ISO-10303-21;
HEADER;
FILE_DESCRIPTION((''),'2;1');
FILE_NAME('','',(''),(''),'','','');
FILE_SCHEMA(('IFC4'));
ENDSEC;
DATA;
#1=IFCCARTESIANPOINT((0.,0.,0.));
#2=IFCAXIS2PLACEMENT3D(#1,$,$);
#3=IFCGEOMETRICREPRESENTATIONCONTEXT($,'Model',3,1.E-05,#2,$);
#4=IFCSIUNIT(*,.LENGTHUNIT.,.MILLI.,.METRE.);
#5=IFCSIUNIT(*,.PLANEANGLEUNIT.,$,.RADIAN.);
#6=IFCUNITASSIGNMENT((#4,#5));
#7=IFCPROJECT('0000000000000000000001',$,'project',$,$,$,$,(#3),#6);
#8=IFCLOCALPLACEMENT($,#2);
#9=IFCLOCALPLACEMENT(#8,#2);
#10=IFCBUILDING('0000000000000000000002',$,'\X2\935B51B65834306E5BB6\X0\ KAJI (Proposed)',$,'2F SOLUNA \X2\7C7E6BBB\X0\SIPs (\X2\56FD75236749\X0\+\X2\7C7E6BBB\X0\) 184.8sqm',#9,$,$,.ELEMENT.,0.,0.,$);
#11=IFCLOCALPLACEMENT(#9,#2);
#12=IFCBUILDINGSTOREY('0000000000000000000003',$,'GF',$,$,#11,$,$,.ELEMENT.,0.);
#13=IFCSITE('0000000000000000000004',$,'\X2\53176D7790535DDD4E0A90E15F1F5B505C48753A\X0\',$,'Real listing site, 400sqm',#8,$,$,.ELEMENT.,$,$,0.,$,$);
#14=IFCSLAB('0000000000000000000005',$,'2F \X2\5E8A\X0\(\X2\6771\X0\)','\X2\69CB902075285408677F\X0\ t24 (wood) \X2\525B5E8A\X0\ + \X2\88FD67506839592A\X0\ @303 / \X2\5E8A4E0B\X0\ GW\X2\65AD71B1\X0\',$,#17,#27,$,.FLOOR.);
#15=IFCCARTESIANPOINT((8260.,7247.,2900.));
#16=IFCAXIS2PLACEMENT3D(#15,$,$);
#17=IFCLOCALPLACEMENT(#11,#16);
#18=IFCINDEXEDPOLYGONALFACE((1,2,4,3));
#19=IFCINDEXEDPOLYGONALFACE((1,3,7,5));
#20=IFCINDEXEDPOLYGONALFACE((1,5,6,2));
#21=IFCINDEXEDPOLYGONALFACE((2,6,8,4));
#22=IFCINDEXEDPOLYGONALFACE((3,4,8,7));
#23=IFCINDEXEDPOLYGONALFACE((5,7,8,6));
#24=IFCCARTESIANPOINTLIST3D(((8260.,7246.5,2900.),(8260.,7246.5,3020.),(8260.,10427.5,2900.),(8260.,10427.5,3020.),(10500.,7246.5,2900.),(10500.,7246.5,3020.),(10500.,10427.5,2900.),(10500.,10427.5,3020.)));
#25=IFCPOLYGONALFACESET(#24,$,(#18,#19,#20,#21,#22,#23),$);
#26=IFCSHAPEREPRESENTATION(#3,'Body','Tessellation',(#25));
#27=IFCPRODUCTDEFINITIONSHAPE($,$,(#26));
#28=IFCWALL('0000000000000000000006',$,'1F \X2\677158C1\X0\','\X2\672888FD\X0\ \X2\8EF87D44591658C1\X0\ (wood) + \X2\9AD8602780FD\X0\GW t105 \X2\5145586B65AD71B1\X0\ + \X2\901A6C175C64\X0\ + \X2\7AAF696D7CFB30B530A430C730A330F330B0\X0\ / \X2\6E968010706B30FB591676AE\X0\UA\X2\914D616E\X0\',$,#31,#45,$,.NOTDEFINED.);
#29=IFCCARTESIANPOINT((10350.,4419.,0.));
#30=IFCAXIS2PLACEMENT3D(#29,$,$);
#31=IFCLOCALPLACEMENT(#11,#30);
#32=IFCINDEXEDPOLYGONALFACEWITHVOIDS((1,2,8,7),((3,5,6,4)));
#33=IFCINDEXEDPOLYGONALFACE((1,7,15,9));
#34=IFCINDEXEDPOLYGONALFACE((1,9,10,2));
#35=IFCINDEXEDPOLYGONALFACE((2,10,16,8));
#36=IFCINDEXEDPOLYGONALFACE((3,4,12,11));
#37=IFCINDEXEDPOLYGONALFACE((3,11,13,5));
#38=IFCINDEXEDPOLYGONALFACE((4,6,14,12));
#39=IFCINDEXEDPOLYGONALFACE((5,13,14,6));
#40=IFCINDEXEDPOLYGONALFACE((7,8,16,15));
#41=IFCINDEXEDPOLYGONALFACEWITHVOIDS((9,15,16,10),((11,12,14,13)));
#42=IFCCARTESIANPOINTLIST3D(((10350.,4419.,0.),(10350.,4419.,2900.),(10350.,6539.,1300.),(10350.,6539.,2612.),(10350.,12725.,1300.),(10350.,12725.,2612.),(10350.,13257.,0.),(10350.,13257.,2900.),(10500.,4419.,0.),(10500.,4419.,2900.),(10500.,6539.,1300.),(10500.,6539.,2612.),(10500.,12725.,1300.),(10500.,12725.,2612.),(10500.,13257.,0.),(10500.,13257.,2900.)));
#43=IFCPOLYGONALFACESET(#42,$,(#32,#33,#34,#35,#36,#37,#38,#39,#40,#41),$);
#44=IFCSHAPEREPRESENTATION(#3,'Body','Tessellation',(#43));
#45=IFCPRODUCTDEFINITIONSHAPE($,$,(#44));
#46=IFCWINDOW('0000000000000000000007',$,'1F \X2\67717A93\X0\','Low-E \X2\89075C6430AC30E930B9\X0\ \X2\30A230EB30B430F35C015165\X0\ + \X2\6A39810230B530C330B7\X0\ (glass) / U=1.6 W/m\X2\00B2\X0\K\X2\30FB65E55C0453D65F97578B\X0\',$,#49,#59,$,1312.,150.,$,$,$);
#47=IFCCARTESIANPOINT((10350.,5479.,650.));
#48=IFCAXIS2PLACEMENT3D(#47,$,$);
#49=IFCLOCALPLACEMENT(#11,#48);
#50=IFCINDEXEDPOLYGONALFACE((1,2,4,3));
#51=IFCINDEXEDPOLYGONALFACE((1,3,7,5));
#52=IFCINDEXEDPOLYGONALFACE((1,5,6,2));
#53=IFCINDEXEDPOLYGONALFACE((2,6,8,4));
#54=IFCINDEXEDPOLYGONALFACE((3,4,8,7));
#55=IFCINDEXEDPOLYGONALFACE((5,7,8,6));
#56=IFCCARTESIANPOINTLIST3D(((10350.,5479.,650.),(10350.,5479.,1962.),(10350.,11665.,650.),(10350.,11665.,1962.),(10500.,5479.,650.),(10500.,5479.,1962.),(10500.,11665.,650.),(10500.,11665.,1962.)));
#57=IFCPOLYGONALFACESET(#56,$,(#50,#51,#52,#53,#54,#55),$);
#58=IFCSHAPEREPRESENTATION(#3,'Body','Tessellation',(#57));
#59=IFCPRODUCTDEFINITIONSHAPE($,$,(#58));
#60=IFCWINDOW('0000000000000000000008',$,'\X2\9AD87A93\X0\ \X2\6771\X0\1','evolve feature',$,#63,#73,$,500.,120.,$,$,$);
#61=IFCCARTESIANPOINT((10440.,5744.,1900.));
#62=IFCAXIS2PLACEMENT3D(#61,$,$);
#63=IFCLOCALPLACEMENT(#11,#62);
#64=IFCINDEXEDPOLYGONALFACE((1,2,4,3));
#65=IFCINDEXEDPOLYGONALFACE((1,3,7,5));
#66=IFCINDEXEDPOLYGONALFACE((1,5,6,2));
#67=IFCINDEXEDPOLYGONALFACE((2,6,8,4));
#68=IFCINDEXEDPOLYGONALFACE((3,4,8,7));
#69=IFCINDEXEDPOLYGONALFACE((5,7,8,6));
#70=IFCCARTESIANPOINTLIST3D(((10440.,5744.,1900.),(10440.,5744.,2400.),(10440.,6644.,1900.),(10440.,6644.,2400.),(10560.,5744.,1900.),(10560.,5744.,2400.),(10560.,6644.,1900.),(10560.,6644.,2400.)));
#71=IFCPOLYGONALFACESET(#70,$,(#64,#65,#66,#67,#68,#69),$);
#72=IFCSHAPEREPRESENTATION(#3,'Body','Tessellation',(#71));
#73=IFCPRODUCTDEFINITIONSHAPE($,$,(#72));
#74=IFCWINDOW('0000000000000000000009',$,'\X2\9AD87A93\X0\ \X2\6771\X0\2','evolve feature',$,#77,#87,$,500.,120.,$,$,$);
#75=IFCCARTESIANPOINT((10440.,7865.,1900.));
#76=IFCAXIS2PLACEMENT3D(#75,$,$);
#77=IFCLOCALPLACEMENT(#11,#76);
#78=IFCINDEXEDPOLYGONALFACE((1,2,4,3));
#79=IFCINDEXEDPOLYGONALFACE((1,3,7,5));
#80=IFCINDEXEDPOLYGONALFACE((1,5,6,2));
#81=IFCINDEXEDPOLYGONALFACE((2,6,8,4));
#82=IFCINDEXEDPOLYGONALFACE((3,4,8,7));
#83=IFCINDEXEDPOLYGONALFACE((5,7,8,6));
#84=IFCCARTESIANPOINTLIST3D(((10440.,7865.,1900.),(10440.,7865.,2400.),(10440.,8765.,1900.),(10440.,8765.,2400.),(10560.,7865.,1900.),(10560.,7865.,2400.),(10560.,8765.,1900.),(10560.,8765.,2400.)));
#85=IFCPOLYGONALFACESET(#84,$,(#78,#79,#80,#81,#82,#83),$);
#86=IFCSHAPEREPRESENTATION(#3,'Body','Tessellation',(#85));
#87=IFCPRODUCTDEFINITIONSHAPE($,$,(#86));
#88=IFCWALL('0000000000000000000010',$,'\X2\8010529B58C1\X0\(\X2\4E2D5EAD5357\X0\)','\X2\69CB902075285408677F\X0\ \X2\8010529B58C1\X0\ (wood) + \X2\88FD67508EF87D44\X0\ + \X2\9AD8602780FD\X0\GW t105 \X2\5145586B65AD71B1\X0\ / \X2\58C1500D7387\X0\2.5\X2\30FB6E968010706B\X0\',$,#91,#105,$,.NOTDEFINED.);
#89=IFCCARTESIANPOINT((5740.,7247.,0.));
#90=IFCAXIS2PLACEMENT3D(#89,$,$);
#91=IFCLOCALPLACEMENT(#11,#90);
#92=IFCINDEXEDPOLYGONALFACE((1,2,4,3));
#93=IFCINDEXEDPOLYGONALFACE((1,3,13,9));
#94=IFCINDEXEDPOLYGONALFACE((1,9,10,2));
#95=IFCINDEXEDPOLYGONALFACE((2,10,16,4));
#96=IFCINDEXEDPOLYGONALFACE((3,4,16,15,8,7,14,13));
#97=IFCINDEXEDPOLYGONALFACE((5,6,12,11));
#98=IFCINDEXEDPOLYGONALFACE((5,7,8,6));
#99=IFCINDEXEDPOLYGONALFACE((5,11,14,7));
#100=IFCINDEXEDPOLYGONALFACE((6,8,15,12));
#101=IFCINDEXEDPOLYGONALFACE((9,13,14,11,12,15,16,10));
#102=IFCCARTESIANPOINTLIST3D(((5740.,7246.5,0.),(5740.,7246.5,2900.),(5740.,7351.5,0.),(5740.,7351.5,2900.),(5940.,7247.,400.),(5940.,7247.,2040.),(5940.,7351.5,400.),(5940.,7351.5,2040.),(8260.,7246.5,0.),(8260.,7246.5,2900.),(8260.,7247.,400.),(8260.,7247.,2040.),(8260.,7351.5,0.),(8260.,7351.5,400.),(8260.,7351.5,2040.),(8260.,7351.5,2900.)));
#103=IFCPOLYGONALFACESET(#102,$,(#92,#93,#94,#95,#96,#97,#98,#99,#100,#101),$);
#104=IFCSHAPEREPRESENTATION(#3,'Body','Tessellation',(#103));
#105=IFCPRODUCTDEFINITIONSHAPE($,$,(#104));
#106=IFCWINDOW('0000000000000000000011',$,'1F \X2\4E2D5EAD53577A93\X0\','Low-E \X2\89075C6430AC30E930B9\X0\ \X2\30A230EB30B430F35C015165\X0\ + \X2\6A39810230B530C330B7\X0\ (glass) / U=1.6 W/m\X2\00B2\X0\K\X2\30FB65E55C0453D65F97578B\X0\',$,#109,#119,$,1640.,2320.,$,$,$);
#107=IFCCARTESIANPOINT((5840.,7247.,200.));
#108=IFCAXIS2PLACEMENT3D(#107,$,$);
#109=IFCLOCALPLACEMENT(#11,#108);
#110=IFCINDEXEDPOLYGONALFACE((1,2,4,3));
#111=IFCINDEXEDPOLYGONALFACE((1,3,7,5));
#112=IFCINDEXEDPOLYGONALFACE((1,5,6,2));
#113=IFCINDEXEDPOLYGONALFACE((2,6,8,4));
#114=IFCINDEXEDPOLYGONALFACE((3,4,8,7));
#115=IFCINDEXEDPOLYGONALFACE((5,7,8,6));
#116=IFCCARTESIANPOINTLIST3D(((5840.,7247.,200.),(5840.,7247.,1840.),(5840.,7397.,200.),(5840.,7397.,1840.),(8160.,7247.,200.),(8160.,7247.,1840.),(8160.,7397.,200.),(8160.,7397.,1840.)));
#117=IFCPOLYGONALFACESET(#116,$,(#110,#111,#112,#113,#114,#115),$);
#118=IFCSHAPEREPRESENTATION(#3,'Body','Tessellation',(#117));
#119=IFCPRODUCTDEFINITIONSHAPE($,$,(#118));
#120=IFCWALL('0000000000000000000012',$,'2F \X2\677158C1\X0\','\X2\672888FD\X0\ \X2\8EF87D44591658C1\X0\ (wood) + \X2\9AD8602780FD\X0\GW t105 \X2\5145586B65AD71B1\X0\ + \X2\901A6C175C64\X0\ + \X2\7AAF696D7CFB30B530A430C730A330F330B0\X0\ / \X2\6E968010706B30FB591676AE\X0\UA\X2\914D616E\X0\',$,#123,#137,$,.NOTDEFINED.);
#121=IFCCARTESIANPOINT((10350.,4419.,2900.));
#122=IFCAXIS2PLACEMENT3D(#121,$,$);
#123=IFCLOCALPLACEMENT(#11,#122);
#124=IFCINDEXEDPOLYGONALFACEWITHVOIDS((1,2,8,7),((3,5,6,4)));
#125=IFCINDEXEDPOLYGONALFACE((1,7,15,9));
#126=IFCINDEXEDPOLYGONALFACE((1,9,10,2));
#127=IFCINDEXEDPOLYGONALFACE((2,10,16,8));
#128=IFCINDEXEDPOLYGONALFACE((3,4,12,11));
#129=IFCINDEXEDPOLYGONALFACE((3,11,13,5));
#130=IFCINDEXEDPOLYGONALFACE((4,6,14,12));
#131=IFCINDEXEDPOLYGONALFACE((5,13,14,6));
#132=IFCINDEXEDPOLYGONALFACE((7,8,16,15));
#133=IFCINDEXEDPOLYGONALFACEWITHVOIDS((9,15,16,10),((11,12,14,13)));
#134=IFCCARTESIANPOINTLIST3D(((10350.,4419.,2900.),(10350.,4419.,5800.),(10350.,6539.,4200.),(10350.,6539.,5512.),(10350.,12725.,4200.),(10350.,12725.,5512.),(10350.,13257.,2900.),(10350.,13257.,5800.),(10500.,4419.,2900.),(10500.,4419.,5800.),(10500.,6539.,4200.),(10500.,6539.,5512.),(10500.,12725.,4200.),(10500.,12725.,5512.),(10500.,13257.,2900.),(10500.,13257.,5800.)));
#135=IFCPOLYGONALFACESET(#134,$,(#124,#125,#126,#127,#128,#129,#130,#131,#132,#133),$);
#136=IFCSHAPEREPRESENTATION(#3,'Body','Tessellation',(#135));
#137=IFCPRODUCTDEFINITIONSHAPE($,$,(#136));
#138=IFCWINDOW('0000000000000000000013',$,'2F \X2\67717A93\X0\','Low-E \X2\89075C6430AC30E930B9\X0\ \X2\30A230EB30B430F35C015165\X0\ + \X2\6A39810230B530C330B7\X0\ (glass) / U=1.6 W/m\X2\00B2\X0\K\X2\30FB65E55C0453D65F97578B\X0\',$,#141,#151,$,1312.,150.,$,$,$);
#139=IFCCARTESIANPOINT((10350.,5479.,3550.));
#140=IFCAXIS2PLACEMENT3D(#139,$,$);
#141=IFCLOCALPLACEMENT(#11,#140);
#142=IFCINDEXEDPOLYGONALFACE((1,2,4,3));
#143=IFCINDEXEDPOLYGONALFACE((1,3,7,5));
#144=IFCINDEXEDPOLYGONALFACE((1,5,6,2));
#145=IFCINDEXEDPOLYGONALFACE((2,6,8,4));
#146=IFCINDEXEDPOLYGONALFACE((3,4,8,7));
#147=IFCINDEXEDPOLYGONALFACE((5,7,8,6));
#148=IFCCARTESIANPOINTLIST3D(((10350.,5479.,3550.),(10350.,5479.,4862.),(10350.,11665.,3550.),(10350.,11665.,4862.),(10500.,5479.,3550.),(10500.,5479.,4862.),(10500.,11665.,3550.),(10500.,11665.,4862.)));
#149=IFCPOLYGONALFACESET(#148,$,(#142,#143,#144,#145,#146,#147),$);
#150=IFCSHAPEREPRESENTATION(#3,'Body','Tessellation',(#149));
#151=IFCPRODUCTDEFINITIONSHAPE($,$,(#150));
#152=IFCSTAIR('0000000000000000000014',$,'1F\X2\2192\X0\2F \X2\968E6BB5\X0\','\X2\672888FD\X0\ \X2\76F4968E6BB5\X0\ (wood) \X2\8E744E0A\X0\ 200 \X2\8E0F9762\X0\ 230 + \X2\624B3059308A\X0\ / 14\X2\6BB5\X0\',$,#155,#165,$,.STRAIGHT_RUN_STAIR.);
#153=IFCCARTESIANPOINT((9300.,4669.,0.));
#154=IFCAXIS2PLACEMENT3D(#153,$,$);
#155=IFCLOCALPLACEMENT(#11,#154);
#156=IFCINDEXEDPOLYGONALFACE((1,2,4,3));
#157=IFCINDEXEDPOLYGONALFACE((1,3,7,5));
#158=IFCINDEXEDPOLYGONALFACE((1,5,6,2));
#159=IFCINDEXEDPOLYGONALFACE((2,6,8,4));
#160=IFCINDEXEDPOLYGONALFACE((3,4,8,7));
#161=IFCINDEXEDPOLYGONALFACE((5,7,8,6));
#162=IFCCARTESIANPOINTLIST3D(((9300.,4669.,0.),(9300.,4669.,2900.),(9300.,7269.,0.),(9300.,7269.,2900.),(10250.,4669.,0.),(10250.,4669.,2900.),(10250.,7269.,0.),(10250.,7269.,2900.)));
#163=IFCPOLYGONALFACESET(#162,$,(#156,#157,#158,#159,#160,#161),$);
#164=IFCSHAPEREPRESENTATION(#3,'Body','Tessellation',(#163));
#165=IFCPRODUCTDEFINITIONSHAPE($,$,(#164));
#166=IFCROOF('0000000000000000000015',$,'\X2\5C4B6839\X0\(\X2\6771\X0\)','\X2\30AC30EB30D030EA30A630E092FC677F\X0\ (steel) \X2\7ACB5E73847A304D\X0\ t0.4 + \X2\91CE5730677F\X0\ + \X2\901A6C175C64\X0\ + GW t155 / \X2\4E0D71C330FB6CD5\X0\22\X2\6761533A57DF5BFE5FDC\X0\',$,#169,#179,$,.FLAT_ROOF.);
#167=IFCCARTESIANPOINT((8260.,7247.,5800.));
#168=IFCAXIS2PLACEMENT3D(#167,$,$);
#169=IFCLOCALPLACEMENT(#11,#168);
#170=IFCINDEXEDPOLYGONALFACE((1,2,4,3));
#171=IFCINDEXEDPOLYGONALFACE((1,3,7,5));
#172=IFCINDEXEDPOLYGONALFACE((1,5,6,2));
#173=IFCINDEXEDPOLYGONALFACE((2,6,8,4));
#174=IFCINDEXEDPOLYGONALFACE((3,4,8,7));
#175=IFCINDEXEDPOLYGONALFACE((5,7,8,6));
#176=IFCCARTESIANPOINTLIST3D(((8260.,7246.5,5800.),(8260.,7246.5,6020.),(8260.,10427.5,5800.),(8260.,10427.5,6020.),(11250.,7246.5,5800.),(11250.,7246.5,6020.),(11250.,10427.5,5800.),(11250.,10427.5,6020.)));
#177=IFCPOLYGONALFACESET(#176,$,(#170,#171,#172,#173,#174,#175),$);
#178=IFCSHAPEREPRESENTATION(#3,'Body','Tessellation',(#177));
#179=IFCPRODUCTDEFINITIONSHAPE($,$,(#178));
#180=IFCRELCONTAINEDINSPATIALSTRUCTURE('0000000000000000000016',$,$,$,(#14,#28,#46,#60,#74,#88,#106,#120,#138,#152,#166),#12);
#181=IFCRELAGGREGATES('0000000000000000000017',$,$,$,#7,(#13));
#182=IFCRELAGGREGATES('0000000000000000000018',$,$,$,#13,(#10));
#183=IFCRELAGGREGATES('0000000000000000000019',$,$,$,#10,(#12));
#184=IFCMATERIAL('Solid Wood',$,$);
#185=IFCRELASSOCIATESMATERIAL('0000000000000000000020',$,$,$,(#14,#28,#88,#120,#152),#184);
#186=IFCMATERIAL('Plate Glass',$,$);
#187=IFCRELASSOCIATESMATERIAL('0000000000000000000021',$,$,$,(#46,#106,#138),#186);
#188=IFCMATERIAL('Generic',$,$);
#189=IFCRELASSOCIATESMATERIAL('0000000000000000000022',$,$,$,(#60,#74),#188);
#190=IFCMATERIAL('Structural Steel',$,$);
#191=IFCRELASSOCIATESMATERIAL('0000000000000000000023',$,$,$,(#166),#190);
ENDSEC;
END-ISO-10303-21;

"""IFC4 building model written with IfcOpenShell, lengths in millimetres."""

from ifc_helpers import new_model, si_unit, frame, frame_2d, origin, place, context, project, spatial, rectangle, extrude, material, element, fill, save


model = new_model("IFC4")

# Units and contexts
model_context = context("Model", 3, precision=1e-05, world=origin())
ifc_project = project(units=[si_unit("LENGTHUNIT", "METRE", prefix="MILLI"), si_unit("PLANEANGLEUNIT", "RADIAN")], contexts=[model_context])

# Site, building, storey
site_placement = place(None, origin())
site = spatial("IfcSite", under=ifc_project, at=site_placement, Name="北海道川上郡弟子屈町", ObjectType="Real listing site, 400sqm", CompositionType="ELEMENT", RefElevation=0.0)
building_placement = place(site_placement, origin())
building = spatial("IfcBuilding", under=site, at=building_placement, Name="鍛冶場の家 KAJI (Proposed)", ObjectType="2F SOLUNA 籾殻SIPs (国産杉+籾殻) 184.8sqm", CompositionType="ELEMENT", ElevationOfRefHeight=0.0, ElevationOfTerrain=0.0)
storey_placement = place(building_placement, origin())
storey = spatial("IfcBuildingStorey", under=building, at=storey_placement, Name="GF", CompositionType="ELEMENT", Elevation=0.0)

# Slab
ifc_material_1 = material(Name="Solid Wood")
slab_1_placement = place(storey_placement, frame((8260.0, 7247.0, 2900.0)))
element("IfcSlab", 1, at=slab_1_placement, inside=storey, material=ifc_material_1, Name="2F 床(東)", Description="構造用合板 t24 (wood) 剛床 + 製材根太 @303 / 床下 GW断熱", PredefinedType="FLOOR", context=model_context, shape_type="SweptSolid", body=[
    extrude(rectangle(XDim=2240.0, YDim=3181.0, at=frame_2d((1120.0, 1590.0))), frame((8260.0, 7247.0, 2900.0)), (0.0, 0.0, 1.0), 120.0),
])

# Wall, openings, windows
wall_1_placement = place(storey_placement, frame((10350.0, 4419.0, 0.0)))
wall_1 = element("IfcWall", 2, at=wall_1_placement, inside=storey, material=ifc_material_1, Name="1F 東壁", Description="木製 軸組外壁 (wood) + 高性能GW t105 充填断熱 + 通気層 + 窯業系サイディング / 準耐火・外皮UA配慮", PredefinedType="NOTDEFINED", context=model_context, shape_type="SweptSolid", body=[
    extrude(rectangle(XDim=150.0, YDim=8838.0, at=frame_2d((75.0, 4419.0))), frame((10350.0, 4419.0, 0.0)), (0.0, 0.0, 1.0), 2900.0),
])
opening_1_placement = place(storey_placement, frame((10350.0, 5479.0, 650.0)))
opening_1 = element("IfcOpeningElement", 3, at=opening_1_placement, cuts=wall_1, PredefinedType="NOTDEFINED", context=model_context, shape_type="SweptSolid", body=[
    extrude(rectangle(XDim=150.0, YDim=6186.0, at=frame_2d((75.0, 3093.0))), frame((10350.0, 5479.0, 650.0)), (0.0, 0.0, 1.0), 1312.0),
])
opening_2_placement = place(storey_placement, frame((10440.0, 5744.0, 1900.0)))
opening_2 = element("IfcOpeningElement", 4, at=opening_2_placement, cuts=wall_1, PredefinedType="NOTDEFINED", context=model_context, shape_type="SweptSolid", body=[
    extrude(rectangle(XDim=120.0, YDim=900.0, at=frame_2d((60.0, 450.0))), frame((10440.0, 5744.0, 1900.0)), (0.0, 0.0, 1.0), 500.0),
])
opening_3_placement = place(storey_placement, frame((10440.0, 7865.0, 1900.0)))
opening_3 = element("IfcOpeningElement", 5, at=opening_3_placement, cuts=wall_1, PredefinedType="NOTDEFINED", context=model_context, shape_type="SweptSolid", body=[
    extrude(rectangle(XDim=120.0, YDim=900.0, at=frame_2d((60.0, 450.0))), frame((10440.0, 7865.0, 1900.0)), (0.0, 0.0, 1.0), 500.0),
])
ifc_material_2 = material(Name="Plate Glass")
window_1_placement = place(storey_placement, frame((10350.0, 5479.0, 650.0)))
window_1 = element("IfcWindow", 6, at=window_1_placement, inside=storey, material=ifc_material_2, Name="1F 東窓", Description="Low-E 複層ガラス アルゴン封入 + 樹脂サッシ (glass) / U=1.6 W/m²K・日射取得型", OverallHeight=1312.0, OverallWidth=150.0, context=model_context, shape_type="SweptSolid", body=[
    extrude(rectangle(XDim=150.0, YDim=6186.0, at=frame_2d((75.0, 3093.0))), frame((10350.0, 5479.0, 650.0)), (0.0, 0.0, 1.0), 1312.0),
])
fill(opening_1, window_1)
ifc_material_3 = material(Name="Generic")
window_2_placement = place(storey_placement, frame((10440.0, 5744.0, 1900.0)))
window_2 = element("IfcWindow", 7, at=window_2_placement, inside=storey, material=ifc_material_3, Name="高窓 東1", Description="evolve feature", OverallHeight=500.0, OverallWidth=120.0, context=model_context, shape_type="SweptSolid", body=[
    extrude(rectangle(XDim=120.0, YDim=900.0, at=frame_2d((60.0, 450.0))), frame((10440.0, 5744.0, 1900.0)), (0.0, 0.0, 1.0), 500.0),
])
fill(opening_2, window_2)
window_3_placement = place(storey_placement, frame((10440.0, 7865.0, 1900.0)))
window_3 = element("IfcWindow", 8, at=window_3_placement, inside=storey, material=ifc_material_3, Name="高窓 東2", Description="evolve feature", OverallHeight=500.0, OverallWidth=120.0, context=model_context, shape_type="SweptSolid", body=[
    extrude(rectangle(XDim=120.0, YDim=900.0, at=frame_2d((60.0, 450.0))), frame((10440.0, 7865.0, 1900.0)), (0.0, 0.0, 1.0), 500.0),
])
fill(opening_3, window_3)

# Wall, opening, window
wall_2_placement = place(storey_placement, frame((5740.0, 7247.0, 0.0)))
wall_2 = element("IfcWall", 9, at=wall_2_placement, inside=storey, material=ifc_material_1, Name="耐力壁(中庭南)", Description="構造用合板 耐力壁 (wood) + 製材軸組 + 高性能GW t105 充填断熱 / 壁倍率2.5・準耐火", PredefinedType="NOTDEFINED", context=model_context, shape_type="SweptSolid", body=[
    extrude(rectangle(XDim=2520.0, YDim=105.0, at=frame_2d((1260.0, 52.0))), frame((5740.0, 7247.0, 0.0)), (0.0, 0.0, 1.0), 2900.0),
])
opening_4_placement = place(storey_placement, frame((5840.0, 7247.0, 200.0)))
opening_4 = element("IfcOpeningElement", 10, at=opening_4_placement, cuts=wall_2, PredefinedType="NOTDEFINED", context=model_context, shape_type="SweptSolid", body=[
    extrude(rectangle(XDim=2320.0, YDim=150.0, at=frame_2d((1160.0, 75.0))), frame((5840.0, 7247.0, 200.0)), (0.0, 0.0, 1.0), 1640.0),
])
window_4_placement = place(storey_placement, frame((5840.0, 7247.0, 200.0)))
window_4 = element("IfcWindow", 11, at=window_4_placement, inside=storey, material=ifc_material_2, Name="1F 中庭南窓", Description="Low-E 複層ガラス アルゴン封入 + 樹脂サッシ (glass) / U=1.6 W/m²K・日射取得型", OverallHeight=1640.0, OverallWidth=2320.0, context=model_context, shape_type="SweptSolid", body=[
    extrude(rectangle(XDim=2320.0, YDim=150.0, at=frame_2d((1160.0, 75.0))), frame((5840.0, 7247.0, 200.0)), (0.0, 0.0, 1.0), 1640.0),
])
fill(opening_4, window_4)

# Wall, opening, window
wall_3_placement = place(storey_placement, frame((10350.0, 4419.0, 2900.0)))
wall_3 = element("IfcWall", 12, at=wall_3_placement, inside=storey, material=ifc_material_1, Name="2F 東壁", Description="木製 軸組外壁 (wood) + 高性能GW t105 充填断熱 + 通気層 + 窯業系サイディング / 準耐火・外皮UA配慮", PredefinedType="NOTDEFINED", context=model_context, shape_type="SweptSolid", body=[
    extrude(rectangle(XDim=150.0, YDim=8838.0, at=frame_2d((75.0, 4419.0))), frame((10350.0, 4419.0, 2900.0)), (0.0, 0.0, 1.0), 2900.0),
])
opening_5_placement = place(storey_placement, frame((10350.0, 5479.0, 3550.0)))
opening_5 = element("IfcOpeningElement", 13, at=opening_5_placement, cuts=wall_3, PredefinedType="NOTDEFINED", context=model_context, shape_type="SweptSolid", body=[
    extrude(rectangle(XDim=150.0, YDim=6186.0, at=frame_2d((75.0, 3093.0))), frame((10350.0, 5479.0, 3550.0)), (0.0, 0.0, 1.0), 1312.0),
])
window_5_placement = place(storey_placement, frame((10350.0, 5479.0, 3550.0)))
window_5 = element("IfcWindow", 14, at=window_5_placement, inside=storey, material=ifc_material_2, Name="2F 東窓", Description="Low-E 複層ガラス アルゴン封入 + 樹脂サッシ (glass) / U=1.6 W/m²K・日射取得型", OverallHeight=1312.0, OverallWidth=150.0, context=model_context, shape_type="SweptSolid", body=[
    extrude(rectangle(XDim=150.0, YDim=6186.0, at=frame_2d((75.0, 3093.0))), frame((10350.0, 5479.0, 3550.0)), (0.0, 0.0, 1.0), 1312.0),
])
fill(opening_5, window_5)

# Stair
stair_placement = place(storey_placement, frame((9300.0, 4669.0, 0.0)))
element("IfcStair", 15, at=stair_placement, inside=storey, material=ifc_material_1, Name="1F→2F 階段", Description="木製 直階段 (wood) 蹴上 200 踏面 230 + 手すり / 14段", PredefinedType="STRAIGHT_RUN_STAIR", context=model_context, shape_type="SweptSolid", body=[
    extrude(rectangle(XDim=950.0, YDim=2600.0, at=frame_2d((475.0, 1300.0))), frame((9300.0, 4669.0, 0.0)), (0.0, 0.0, 1.0), 2900.0),
])

# Roof
ifc_material_4 = material(Name="Structural Steel")
roof_placement = place(storey_placement, frame((8260.0, 7247.0, 5800.0)))
element("IfcRoof", 16, at=roof_placement, inside=storey, material=ifc_material_4, Name="屋根(東)", Description="ガルバリウム鋼板 (steel) 立平葺き t0.4 + 野地板 + 通気層 + GW t155 / 不燃・法22条区域対応", PredefinedType="FLAT_ROOF", context=model_context, shape_type="SweptSolid", body=[
    extrude(rectangle(XDim=2990.0, YDim=3181.0, at=frame_2d((1495.0, 1590.0))), frame((8260.0, 7247.0, 5800.0)), (0.0, 0.0, 1.0), 220.0),
])

save(model, "model.ifc")
